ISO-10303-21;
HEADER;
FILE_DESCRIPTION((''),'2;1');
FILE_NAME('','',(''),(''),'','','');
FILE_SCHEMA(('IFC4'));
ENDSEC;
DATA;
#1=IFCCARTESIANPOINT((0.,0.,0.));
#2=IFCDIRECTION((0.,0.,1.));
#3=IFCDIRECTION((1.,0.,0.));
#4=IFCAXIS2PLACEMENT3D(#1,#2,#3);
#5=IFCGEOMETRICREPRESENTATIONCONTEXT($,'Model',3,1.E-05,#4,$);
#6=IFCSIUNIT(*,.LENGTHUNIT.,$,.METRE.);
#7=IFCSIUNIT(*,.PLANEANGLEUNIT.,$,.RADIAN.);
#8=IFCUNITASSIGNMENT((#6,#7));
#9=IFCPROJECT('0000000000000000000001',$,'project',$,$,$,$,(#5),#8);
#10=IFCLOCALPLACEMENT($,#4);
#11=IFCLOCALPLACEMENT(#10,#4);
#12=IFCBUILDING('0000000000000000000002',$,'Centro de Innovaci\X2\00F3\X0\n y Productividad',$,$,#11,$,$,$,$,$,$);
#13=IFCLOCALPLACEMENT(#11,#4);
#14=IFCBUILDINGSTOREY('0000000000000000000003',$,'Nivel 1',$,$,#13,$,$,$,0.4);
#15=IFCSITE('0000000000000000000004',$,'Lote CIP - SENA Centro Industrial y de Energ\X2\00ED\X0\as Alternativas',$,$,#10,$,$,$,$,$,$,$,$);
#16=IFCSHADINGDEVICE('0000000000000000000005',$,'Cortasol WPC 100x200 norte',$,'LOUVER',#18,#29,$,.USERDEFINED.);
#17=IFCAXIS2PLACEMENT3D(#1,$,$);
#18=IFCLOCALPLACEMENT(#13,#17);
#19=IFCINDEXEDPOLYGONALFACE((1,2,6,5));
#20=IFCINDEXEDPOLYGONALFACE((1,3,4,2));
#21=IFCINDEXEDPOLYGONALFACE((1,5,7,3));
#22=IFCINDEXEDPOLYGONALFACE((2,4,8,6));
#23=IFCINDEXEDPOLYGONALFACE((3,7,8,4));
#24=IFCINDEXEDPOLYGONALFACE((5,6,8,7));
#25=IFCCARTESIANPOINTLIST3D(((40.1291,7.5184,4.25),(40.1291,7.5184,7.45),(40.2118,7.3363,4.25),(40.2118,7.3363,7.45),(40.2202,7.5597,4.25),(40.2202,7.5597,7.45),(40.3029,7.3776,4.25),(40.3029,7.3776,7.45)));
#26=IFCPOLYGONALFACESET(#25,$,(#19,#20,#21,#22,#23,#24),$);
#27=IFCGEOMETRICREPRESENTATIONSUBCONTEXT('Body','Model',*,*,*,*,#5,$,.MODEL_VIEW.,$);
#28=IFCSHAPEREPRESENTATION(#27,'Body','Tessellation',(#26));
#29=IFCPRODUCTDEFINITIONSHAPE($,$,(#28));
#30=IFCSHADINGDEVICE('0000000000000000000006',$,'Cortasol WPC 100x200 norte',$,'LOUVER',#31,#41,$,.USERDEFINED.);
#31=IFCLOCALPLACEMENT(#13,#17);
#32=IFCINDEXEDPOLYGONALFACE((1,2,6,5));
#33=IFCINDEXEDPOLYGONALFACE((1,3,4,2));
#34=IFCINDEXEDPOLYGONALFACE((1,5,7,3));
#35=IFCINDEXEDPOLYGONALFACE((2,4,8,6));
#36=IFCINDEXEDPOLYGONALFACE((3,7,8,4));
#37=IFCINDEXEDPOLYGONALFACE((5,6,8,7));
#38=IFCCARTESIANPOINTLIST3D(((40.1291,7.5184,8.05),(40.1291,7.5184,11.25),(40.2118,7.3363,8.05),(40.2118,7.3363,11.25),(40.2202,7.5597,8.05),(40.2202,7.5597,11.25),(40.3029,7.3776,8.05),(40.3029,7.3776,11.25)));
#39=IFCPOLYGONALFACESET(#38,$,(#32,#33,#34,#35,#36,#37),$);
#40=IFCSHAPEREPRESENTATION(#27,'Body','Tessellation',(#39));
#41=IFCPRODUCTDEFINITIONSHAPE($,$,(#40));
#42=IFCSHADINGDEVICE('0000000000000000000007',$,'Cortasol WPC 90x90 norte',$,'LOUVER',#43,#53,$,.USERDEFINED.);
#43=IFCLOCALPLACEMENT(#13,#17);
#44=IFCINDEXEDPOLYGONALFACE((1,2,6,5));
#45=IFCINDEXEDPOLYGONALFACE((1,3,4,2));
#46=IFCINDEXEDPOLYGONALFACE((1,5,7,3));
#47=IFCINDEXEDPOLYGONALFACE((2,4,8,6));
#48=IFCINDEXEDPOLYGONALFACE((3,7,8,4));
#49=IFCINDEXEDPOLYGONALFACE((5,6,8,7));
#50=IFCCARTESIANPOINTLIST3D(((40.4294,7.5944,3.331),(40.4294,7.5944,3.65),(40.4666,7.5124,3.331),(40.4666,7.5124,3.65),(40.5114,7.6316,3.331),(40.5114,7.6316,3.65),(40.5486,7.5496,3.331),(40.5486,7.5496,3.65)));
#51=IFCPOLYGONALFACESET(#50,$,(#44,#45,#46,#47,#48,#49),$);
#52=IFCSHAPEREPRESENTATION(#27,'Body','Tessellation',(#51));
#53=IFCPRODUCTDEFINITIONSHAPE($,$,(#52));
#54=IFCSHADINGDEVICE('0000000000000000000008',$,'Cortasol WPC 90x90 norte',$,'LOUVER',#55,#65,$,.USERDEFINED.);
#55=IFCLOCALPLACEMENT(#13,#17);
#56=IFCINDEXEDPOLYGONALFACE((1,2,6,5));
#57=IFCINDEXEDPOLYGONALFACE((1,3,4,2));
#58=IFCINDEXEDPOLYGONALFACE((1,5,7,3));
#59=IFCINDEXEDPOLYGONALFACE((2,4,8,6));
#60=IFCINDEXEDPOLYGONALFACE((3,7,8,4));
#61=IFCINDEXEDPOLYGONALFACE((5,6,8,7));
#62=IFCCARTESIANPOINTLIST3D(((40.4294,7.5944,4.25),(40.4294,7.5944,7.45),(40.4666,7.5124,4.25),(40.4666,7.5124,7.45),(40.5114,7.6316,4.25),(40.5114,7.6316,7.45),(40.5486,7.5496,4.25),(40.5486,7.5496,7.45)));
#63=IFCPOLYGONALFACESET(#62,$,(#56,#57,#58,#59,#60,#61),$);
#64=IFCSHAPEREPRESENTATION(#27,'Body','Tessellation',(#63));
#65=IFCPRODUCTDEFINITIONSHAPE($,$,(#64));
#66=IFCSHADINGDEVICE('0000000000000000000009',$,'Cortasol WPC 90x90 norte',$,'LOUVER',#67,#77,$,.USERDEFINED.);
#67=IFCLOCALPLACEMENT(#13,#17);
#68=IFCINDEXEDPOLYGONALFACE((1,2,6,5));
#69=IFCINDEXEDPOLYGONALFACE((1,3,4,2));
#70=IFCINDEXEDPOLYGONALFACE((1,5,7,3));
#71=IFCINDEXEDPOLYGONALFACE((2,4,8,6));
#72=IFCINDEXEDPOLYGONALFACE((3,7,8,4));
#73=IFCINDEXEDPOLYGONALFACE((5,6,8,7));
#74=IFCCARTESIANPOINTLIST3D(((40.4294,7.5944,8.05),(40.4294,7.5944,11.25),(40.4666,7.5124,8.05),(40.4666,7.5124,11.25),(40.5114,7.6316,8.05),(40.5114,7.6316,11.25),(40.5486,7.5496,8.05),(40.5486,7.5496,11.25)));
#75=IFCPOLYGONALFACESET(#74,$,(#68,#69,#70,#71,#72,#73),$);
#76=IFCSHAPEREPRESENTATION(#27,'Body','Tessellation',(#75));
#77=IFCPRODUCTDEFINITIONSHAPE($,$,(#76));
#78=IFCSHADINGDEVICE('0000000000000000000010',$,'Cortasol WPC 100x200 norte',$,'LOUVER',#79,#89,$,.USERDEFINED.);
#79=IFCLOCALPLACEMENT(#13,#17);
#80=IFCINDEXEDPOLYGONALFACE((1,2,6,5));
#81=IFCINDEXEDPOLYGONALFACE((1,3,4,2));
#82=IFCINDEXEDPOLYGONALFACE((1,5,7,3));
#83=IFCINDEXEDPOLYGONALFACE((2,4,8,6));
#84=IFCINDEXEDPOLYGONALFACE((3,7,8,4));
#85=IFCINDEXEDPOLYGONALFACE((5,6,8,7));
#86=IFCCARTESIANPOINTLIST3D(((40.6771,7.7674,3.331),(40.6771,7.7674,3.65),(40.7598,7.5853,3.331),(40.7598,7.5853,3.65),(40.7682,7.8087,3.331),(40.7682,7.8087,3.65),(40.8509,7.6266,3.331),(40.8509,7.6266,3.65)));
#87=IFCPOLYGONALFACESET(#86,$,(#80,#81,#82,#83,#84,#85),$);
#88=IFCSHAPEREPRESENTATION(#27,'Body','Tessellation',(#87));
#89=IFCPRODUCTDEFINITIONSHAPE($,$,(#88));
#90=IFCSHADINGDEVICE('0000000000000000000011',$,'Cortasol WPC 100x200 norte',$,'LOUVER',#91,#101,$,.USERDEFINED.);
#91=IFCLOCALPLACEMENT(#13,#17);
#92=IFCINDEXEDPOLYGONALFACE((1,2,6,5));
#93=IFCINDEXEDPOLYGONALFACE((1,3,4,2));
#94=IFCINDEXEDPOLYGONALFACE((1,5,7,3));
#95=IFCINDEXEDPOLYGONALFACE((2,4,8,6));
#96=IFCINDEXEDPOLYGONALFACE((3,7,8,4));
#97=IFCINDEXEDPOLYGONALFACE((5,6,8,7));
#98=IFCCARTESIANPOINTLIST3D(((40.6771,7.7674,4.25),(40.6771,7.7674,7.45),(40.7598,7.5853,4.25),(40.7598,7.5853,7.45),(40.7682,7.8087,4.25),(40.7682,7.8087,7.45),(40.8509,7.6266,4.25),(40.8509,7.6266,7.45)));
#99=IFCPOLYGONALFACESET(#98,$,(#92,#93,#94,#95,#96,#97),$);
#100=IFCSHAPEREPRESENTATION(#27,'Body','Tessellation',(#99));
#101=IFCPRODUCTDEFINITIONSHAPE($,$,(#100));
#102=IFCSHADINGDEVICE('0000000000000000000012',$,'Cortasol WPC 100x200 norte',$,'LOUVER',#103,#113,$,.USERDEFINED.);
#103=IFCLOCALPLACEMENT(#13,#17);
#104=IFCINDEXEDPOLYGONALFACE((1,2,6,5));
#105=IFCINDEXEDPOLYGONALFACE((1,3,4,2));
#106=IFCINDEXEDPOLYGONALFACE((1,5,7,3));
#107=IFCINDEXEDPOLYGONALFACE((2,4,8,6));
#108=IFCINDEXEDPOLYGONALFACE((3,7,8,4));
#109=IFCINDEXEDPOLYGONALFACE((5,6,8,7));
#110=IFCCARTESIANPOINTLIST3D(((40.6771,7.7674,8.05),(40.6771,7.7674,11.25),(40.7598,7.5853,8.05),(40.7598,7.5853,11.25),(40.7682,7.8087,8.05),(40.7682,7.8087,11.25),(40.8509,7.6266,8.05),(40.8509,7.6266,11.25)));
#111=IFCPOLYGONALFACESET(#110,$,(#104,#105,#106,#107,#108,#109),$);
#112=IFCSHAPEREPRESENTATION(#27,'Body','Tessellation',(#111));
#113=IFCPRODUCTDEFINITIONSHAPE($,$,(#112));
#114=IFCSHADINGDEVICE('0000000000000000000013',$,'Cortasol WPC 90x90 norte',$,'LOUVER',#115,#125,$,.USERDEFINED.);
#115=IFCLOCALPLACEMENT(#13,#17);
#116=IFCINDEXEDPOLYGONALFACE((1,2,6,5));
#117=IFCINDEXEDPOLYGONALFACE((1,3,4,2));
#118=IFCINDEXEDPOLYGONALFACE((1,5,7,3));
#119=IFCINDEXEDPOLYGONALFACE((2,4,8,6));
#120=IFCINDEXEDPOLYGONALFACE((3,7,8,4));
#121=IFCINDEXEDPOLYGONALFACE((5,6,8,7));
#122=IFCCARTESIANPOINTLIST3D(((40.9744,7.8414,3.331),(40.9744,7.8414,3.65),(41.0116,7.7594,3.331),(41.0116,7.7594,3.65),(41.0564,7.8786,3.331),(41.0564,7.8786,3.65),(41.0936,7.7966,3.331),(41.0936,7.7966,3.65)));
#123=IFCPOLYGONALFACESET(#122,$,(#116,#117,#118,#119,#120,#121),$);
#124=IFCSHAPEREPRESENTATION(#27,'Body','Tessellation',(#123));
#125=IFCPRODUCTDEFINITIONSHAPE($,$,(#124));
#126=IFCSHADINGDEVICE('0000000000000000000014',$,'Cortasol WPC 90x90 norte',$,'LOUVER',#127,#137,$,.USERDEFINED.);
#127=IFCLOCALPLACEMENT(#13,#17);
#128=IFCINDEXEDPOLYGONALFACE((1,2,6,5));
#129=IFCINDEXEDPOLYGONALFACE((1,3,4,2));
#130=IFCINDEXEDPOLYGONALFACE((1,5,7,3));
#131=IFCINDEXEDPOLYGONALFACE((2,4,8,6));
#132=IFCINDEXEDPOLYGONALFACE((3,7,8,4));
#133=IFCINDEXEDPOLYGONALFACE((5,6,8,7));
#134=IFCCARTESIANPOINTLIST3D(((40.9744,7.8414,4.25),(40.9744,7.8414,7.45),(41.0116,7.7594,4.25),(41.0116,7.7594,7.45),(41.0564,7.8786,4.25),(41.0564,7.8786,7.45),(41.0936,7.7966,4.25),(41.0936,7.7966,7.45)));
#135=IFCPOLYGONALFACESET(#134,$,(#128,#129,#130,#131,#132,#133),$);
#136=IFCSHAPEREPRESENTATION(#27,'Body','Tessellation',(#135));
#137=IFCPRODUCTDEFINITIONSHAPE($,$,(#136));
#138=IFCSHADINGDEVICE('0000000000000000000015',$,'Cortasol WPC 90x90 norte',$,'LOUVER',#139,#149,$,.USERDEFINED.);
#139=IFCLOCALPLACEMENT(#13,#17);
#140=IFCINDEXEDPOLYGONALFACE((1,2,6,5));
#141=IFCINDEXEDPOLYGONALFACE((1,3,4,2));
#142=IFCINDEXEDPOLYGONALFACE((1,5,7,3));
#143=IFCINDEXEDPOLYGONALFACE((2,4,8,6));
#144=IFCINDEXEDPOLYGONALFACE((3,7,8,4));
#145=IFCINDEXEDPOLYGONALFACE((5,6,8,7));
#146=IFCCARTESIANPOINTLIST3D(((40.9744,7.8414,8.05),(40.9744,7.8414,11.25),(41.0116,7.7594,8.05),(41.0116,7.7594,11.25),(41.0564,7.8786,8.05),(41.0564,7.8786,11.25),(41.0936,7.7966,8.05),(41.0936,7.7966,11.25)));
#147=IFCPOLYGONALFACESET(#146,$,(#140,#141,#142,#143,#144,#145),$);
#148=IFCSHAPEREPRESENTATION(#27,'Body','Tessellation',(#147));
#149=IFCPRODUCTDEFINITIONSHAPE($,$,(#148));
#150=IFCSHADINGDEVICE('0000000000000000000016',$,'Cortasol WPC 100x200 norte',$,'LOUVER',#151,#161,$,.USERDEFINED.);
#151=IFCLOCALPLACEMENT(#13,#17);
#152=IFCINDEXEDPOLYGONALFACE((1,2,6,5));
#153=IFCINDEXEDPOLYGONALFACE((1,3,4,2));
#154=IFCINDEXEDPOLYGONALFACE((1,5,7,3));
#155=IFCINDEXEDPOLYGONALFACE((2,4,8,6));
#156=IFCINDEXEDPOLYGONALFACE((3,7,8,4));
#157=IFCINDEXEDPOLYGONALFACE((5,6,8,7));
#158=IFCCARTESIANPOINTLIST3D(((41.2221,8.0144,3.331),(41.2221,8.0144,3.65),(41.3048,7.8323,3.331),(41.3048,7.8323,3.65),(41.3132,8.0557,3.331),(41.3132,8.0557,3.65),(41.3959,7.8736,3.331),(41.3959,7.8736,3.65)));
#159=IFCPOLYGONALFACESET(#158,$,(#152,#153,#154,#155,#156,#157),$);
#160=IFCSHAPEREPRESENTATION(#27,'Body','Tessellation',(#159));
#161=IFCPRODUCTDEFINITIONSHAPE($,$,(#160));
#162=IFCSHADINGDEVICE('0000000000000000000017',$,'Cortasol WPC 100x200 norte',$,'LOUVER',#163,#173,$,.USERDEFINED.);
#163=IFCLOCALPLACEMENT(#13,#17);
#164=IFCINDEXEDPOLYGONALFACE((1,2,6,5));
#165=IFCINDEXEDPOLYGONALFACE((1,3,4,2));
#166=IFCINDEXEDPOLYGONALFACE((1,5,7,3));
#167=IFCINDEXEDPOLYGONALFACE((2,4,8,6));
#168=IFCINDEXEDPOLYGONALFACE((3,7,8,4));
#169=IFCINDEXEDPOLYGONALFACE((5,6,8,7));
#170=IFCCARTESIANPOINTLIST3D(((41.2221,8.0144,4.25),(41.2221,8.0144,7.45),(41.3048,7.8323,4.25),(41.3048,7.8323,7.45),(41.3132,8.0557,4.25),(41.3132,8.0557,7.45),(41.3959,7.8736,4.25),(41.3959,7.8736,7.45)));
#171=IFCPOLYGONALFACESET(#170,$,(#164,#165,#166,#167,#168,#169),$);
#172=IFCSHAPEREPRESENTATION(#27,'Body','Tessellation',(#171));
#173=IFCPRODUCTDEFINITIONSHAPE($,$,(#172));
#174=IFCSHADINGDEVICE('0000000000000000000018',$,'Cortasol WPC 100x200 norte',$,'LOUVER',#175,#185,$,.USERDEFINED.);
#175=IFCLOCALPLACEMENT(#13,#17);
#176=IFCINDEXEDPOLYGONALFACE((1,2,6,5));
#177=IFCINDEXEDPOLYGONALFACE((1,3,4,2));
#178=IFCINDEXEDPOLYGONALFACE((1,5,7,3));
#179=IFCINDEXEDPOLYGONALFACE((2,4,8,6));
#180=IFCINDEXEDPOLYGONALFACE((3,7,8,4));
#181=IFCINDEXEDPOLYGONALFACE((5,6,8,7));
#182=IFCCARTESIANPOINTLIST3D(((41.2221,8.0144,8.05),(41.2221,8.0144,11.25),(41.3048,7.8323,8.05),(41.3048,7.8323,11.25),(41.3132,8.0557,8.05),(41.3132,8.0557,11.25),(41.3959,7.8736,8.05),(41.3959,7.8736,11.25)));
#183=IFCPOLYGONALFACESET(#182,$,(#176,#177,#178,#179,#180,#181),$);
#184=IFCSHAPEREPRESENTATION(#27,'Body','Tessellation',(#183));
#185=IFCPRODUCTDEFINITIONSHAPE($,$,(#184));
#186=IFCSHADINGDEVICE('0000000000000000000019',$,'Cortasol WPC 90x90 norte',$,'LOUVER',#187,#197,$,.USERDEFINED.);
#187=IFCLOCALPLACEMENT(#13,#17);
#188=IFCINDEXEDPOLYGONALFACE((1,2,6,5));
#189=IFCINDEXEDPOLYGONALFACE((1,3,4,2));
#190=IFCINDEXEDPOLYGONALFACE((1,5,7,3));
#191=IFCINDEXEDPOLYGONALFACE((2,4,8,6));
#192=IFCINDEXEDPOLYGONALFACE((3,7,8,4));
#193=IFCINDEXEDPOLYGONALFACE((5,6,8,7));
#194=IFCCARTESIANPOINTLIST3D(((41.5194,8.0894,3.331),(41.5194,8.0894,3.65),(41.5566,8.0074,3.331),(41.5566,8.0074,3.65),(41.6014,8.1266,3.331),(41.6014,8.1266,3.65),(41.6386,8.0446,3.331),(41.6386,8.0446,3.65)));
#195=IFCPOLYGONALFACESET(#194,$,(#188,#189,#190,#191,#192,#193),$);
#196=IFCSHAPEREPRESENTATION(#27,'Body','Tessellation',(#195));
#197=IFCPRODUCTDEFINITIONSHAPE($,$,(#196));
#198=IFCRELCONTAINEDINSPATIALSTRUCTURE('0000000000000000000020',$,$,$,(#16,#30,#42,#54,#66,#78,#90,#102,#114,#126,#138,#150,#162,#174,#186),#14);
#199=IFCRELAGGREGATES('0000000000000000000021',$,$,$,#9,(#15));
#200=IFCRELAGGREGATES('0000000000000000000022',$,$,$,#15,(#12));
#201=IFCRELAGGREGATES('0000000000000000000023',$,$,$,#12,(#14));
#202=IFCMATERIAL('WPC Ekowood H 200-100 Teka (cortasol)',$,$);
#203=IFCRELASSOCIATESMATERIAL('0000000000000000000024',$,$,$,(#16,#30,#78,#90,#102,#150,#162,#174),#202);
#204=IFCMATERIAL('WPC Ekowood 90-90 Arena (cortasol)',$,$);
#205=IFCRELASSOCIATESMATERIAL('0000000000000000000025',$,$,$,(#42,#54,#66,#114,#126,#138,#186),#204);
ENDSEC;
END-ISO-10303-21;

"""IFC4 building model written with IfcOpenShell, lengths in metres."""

from ifc_helpers import new_model, si_unit, frame, origin_with_axes, place, context, subcontext, project, spatial, polyline, outline, extrude, material, element, save


model = new_model("IFC4")

# Units and contexts
model_context = context("Model", 3, precision=1e-05, world=origin_with_axes())
body_context = subcontext(model_context, "Body", "Model", "MODEL_VIEW")
ifc_project = project(units=[si_unit("LENGTHUNIT", "METRE"), si_unit("PLANEANGLEUNIT", "RADIAN")], contexts=[model_context])

# Site, building, storey
site_placement = place(None, origin_with_axes())
site = spatial("IfcSite", under=ifc_project, at=site_placement, Name="Lote CIP - SENA Centro Industrial y de Energías Alternativas")
building_placement = place(site_placement, origin_with_axes())
building = spatial("IfcBuilding", under=site, at=building_placement, Name="Centro de Innovación y Productividad")
storey_placement = place(building_placement, origin_with_axes())
storey = spatial("IfcBuildingStorey", under=building, at=storey_placement, Name="Nivel 1", Elevation=0.4)

# Shading devices
ifc_material_1 = material(Name="WPC Ekowood H 200-100 Teka (cortasol)")
shading_device_1_placement = place(storey_placement, origin_with_axes())
element("IfcShadingDevice", 1, at=shading_device_1_placement, inside=storey, material=ifc_material_1, Name="Cortasol WPC 100x200 norte", ObjectType="LOUVER", PredefinedType="USERDEFINED", context=body_context, shape_type="SweptSolid", body=[
    extrude(outline(polyline([(40.2118, 7.3363), (40.1291, 7.5184), (40.2202, 7.5597), (40.3029, 7.3776), (40.2118, 7.3363)])), frame((0.0, 0.0, 4.25)), (0.0, 0.0, 1.0), 3.2),
])
shading_device_2_placement = place(storey_placement, origin_with_axes())
element("IfcShadingDevice", 2, at=shading_device_2_placement, inside=storey, material=ifc_material_1, Name="Cortasol WPC 100x200 norte", ObjectType="LOUVER", PredefinedType="USERDEFINED", context=body_context, shape_type="SweptSolid", body=[
    extrude(outline(polyline([(40.2118, 7.3363), (40.1291, 7.5184), (40.2202, 7.5597), (40.3029, 7.3776), (40.2118, 7.3363)])), frame((0.0, 0.0, 8.05)), (0.0, 0.0, 1.0), 3.2),
])
ifc_material_2 = material(Name="WPC Ekowood 90-90 Arena (cortasol)")
shading_device_3_placement = place(storey_placement, origin_with_axes())
element("IfcShadingDevice", 3, at=shading_device_3_placement, inside=storey, material=ifc_material_2, Name="Cortasol WPC 90x90 norte", ObjectType="LOUVER", PredefinedType="USERDEFINED", context=body_context, shape_type="SweptSolid", body=[
    extrude(outline(polyline([(40.4666, 7.5124), (40.4294, 7.5944), (40.5114, 7.6316), (40.5486, 7.5496), (40.4666, 7.5124)])), frame((0.0, 0.0, 3.331)), (0.0, 0.0, 1.0), 0.319),
])
shading_device_4_placement = place(storey_placement, origin_with_axes())
element("IfcShadingDevice", 4, at=shading_device_4_placement, inside=storey, material=ifc_material_2, Name="Cortasol WPC 90x90 norte", ObjectType="LOUVER", PredefinedType="USERDEFINED", context=body_context, shape_type="SweptSolid", body=[
    extrude(outline(polyline([(40.4666, 7.5124), (40.4294, 7.5944), (40.5114, 7.6316), (40.5486, 7.5496), (40.4666, 7.5124)])), frame((0.0, 0.0, 4.25)), (0.0, 0.0, 1.0), 3.2),
])
shading_device_5_placement = place(storey_placement, origin_with_axes())
element("IfcShadingDevice", 5, at=shading_device_5_placement, inside=storey, material=ifc_material_2, Name="Cortasol WPC 90x90 norte", ObjectType="LOUVER", PredefinedType="USERDEFINED", context=body_context, shape_type="SweptSolid", body=[
    extrude(outline(polyline([(40.4666, 7.5124), (40.4294, 7.5944), (40.5114, 7.6316), (40.5486, 7.5496), (40.4666, 7.5124)])), frame((0.0, 0.0, 8.05)), (0.0, 0.0, 1.0), 3.2),
])
shading_device_6_placement = place(storey_placement, origin_with_axes())
element("IfcShadingDevice", 6, at=shading_device_6_placement, inside=storey, material=ifc_material_1, Name="Cortasol WPC 100x200 norte", ObjectType="LOUVER", PredefinedType="USERDEFINED", context=body_context, shape_type="SweptSolid", body=[
    extrude(outline(polyline([(40.7598, 7.5853), (40.6771, 7.7674), (40.7682, 7.8087), (40.8509, 7.6266), (40.7598, 7.5853)])), frame((0.0, 0.0, 3.331)), (0.0, 0.0, 1.0), 0.319),
])
shading_device_7_placement = place(storey_placement, origin_with_axes())
element("IfcShadingDevice", 7, at=shading_device_7_placement, inside=storey, material=ifc_material_1, Name="Cortasol WPC 100x200 norte", ObjectType="LOUVER", PredefinedType="USERDEFINED", context=body_context, shape_type="SweptSolid", body=[
    extrude(outline(polyline([(40.7598, 7.5853), (40.6771, 7.7674), (40.7682, 7.8087), (40.8509, 7.6266), (40.7598, 7.5853)])), frame((0.0, 0.0, 4.25)), (0.0, 0.0, 1.0), 3.2),
])
shading_device_8_placement = place(storey_placement, origin_with_axes())
element("IfcShadingDevice", 8, at=shading_device_8_placement, inside=storey, material=ifc_material_1, Name="Cortasol WPC 100x200 norte", ObjectType="LOUVER", PredefinedType="USERDEFINED", context=body_context, shape_type="SweptSolid", body=[
    extrude(outline(polyline([(40.7598, 7.5853), (40.6771, 7.7674), (40.7682, 7.8087), (40.8509, 7.6266), (40.7598, 7.5853)])), frame((0.0, 0.0, 8.05)), (0.0, 0.0, 1.0), 3.2),
])
shading_device_9_placement = place(storey_placement, origin_with_axes())
element("IfcShadingDevice", 9, at=shading_device_9_placement, inside=storey, material=ifc_material_2, Name="Cortasol WPC 90x90 norte", ObjectType="LOUVER", PredefinedType="USERDEFINED", context=body_context, shape_type="SweptSolid", body=[
    extrude(outline(polyline([(41.0116, 7.7594), (40.9744, 7.8414), (41.0564, 7.8786), (41.0936, 7.7966), (41.0116, 7.7594)])), frame((0.0, 0.0, 3.331)), (0.0, 0.0, 1.0), 0.319),
])
shading_device_10_placement = place(storey_placement, origin_with_axes())
element("IfcShadingDevice", 10, at=shading_device_10_placement, inside=storey, material=ifc_material_2, Name="Cortasol WPC 90x90 norte", ObjectType="LOUVER", PredefinedType="USERDEFINED", context=body_context, shape_type="SweptSolid", body=[
    extrude(outline(polyline([(41.0116, 7.7594), (40.9744, 7.8414), (41.0564, 7.8786), (41.0936, 7.7966), (41.0116, 7.7594)])), frame((0.0, 0.0, 4.25)), (0.0, 0.0, 1.0), 3.2),
])
shading_device_11_placement = place(storey_placement, origin_with_axes())
element("IfcShadingDevice", 11, at=shading_device_11_placement, inside=storey, material=ifc_material_2, Name="Cortasol WPC 90x90 norte", ObjectType="LOUVER", PredefinedType="USERDEFINED", context=body_context, shape_type="SweptSolid", body=[
    extrude(outline(polyline([(41.0116, 7.7594), (40.9744, 7.8414), (41.0564, 7.8786), (41.0936, 7.7966), (41.0116, 7.7594)])), frame((0.0, 0.0, 8.05)), (0.0, 0.0, 1.0), 3.2),
])
shading_device_12_placement = place(storey_placement, origin_with_axes())
element("IfcShadingDevice", 12, at=shading_device_12_placement, inside=storey, material=ifc_material_1, Name="Cortasol WPC 100x200 norte", ObjectType="LOUVER", PredefinedType="USERDEFINED", context=body_context, shape_type="SweptSolid", body=[
    extrude(outline(polyline([(41.3048, 7.8323), (41.2221, 8.0144), (41.3132, 8.0557), (41.3959, 7.8736), (41.3048, 7.8323)])), frame((0.0, 0.0, 3.331)), (0.0, 0.0, 1.0), 0.319),
])
shading_device_13_placement = place(storey_placement, origin_with_axes())
element("IfcShadingDevice", 13, at=shading_device_13_placement, inside=storey, material=ifc_material_1, Name="Cortasol WPC 100x200 norte", ObjectType="LOUVER", PredefinedType="USERDEFINED", context=body_context, shape_type="SweptSolid", body=[
    extrude(outline(polyline([(41.3048, 7.8323), (41.2221, 8.0144), (41.3132, 8.0557), (41.3959, 7.8736), (41.3048, 7.8323)])), frame((0.0, 0.0, 4.25)), (0.0, 0.0, 1.0), 3.2),
])
shading_device_14_placement = place(storey_placement, origin_with_axes())
element("IfcShadingDevice", 14, at=shading_device_14_placement, inside=storey, material=ifc_material_1, Name="Cortasol WPC 100x200 norte", ObjectType="LOUVER", PredefinedType="USERDEFINED", context=body_context, shape_type="SweptSolid", body=[
    extrude(outline(polyline([(41.3048, 7.8323), (41.2221, 8.0144), (41.3132, 8.0557), (41.3959, 7.8736), (41.3048, 7.8323)])), frame((0.0, 0.0, 8.05)), (0.0, 0.0, 1.0), 3.2),
])
shading_device_15_placement = place(storey_placement, origin_with_axes())
element("IfcShadingDevice", 15, at=shading_device_15_placement, inside=storey, material=ifc_material_2, Name="Cortasol WPC 90x90 norte", ObjectType="LOUVER", PredefinedType="USERDEFINED", context=body_context, shape_type="SweptSolid", body=[
    extrude(outline(polyline([(41.5566, 8.0074), (41.5194, 8.0894), (41.6014, 8.1266), (41.6386, 8.0446), (41.5566, 8.0074)])), frame((0.0, 0.0, 3.331)), (0.0, 0.0, 1.0), 0.319),
])

save(model, "model.ifc")
